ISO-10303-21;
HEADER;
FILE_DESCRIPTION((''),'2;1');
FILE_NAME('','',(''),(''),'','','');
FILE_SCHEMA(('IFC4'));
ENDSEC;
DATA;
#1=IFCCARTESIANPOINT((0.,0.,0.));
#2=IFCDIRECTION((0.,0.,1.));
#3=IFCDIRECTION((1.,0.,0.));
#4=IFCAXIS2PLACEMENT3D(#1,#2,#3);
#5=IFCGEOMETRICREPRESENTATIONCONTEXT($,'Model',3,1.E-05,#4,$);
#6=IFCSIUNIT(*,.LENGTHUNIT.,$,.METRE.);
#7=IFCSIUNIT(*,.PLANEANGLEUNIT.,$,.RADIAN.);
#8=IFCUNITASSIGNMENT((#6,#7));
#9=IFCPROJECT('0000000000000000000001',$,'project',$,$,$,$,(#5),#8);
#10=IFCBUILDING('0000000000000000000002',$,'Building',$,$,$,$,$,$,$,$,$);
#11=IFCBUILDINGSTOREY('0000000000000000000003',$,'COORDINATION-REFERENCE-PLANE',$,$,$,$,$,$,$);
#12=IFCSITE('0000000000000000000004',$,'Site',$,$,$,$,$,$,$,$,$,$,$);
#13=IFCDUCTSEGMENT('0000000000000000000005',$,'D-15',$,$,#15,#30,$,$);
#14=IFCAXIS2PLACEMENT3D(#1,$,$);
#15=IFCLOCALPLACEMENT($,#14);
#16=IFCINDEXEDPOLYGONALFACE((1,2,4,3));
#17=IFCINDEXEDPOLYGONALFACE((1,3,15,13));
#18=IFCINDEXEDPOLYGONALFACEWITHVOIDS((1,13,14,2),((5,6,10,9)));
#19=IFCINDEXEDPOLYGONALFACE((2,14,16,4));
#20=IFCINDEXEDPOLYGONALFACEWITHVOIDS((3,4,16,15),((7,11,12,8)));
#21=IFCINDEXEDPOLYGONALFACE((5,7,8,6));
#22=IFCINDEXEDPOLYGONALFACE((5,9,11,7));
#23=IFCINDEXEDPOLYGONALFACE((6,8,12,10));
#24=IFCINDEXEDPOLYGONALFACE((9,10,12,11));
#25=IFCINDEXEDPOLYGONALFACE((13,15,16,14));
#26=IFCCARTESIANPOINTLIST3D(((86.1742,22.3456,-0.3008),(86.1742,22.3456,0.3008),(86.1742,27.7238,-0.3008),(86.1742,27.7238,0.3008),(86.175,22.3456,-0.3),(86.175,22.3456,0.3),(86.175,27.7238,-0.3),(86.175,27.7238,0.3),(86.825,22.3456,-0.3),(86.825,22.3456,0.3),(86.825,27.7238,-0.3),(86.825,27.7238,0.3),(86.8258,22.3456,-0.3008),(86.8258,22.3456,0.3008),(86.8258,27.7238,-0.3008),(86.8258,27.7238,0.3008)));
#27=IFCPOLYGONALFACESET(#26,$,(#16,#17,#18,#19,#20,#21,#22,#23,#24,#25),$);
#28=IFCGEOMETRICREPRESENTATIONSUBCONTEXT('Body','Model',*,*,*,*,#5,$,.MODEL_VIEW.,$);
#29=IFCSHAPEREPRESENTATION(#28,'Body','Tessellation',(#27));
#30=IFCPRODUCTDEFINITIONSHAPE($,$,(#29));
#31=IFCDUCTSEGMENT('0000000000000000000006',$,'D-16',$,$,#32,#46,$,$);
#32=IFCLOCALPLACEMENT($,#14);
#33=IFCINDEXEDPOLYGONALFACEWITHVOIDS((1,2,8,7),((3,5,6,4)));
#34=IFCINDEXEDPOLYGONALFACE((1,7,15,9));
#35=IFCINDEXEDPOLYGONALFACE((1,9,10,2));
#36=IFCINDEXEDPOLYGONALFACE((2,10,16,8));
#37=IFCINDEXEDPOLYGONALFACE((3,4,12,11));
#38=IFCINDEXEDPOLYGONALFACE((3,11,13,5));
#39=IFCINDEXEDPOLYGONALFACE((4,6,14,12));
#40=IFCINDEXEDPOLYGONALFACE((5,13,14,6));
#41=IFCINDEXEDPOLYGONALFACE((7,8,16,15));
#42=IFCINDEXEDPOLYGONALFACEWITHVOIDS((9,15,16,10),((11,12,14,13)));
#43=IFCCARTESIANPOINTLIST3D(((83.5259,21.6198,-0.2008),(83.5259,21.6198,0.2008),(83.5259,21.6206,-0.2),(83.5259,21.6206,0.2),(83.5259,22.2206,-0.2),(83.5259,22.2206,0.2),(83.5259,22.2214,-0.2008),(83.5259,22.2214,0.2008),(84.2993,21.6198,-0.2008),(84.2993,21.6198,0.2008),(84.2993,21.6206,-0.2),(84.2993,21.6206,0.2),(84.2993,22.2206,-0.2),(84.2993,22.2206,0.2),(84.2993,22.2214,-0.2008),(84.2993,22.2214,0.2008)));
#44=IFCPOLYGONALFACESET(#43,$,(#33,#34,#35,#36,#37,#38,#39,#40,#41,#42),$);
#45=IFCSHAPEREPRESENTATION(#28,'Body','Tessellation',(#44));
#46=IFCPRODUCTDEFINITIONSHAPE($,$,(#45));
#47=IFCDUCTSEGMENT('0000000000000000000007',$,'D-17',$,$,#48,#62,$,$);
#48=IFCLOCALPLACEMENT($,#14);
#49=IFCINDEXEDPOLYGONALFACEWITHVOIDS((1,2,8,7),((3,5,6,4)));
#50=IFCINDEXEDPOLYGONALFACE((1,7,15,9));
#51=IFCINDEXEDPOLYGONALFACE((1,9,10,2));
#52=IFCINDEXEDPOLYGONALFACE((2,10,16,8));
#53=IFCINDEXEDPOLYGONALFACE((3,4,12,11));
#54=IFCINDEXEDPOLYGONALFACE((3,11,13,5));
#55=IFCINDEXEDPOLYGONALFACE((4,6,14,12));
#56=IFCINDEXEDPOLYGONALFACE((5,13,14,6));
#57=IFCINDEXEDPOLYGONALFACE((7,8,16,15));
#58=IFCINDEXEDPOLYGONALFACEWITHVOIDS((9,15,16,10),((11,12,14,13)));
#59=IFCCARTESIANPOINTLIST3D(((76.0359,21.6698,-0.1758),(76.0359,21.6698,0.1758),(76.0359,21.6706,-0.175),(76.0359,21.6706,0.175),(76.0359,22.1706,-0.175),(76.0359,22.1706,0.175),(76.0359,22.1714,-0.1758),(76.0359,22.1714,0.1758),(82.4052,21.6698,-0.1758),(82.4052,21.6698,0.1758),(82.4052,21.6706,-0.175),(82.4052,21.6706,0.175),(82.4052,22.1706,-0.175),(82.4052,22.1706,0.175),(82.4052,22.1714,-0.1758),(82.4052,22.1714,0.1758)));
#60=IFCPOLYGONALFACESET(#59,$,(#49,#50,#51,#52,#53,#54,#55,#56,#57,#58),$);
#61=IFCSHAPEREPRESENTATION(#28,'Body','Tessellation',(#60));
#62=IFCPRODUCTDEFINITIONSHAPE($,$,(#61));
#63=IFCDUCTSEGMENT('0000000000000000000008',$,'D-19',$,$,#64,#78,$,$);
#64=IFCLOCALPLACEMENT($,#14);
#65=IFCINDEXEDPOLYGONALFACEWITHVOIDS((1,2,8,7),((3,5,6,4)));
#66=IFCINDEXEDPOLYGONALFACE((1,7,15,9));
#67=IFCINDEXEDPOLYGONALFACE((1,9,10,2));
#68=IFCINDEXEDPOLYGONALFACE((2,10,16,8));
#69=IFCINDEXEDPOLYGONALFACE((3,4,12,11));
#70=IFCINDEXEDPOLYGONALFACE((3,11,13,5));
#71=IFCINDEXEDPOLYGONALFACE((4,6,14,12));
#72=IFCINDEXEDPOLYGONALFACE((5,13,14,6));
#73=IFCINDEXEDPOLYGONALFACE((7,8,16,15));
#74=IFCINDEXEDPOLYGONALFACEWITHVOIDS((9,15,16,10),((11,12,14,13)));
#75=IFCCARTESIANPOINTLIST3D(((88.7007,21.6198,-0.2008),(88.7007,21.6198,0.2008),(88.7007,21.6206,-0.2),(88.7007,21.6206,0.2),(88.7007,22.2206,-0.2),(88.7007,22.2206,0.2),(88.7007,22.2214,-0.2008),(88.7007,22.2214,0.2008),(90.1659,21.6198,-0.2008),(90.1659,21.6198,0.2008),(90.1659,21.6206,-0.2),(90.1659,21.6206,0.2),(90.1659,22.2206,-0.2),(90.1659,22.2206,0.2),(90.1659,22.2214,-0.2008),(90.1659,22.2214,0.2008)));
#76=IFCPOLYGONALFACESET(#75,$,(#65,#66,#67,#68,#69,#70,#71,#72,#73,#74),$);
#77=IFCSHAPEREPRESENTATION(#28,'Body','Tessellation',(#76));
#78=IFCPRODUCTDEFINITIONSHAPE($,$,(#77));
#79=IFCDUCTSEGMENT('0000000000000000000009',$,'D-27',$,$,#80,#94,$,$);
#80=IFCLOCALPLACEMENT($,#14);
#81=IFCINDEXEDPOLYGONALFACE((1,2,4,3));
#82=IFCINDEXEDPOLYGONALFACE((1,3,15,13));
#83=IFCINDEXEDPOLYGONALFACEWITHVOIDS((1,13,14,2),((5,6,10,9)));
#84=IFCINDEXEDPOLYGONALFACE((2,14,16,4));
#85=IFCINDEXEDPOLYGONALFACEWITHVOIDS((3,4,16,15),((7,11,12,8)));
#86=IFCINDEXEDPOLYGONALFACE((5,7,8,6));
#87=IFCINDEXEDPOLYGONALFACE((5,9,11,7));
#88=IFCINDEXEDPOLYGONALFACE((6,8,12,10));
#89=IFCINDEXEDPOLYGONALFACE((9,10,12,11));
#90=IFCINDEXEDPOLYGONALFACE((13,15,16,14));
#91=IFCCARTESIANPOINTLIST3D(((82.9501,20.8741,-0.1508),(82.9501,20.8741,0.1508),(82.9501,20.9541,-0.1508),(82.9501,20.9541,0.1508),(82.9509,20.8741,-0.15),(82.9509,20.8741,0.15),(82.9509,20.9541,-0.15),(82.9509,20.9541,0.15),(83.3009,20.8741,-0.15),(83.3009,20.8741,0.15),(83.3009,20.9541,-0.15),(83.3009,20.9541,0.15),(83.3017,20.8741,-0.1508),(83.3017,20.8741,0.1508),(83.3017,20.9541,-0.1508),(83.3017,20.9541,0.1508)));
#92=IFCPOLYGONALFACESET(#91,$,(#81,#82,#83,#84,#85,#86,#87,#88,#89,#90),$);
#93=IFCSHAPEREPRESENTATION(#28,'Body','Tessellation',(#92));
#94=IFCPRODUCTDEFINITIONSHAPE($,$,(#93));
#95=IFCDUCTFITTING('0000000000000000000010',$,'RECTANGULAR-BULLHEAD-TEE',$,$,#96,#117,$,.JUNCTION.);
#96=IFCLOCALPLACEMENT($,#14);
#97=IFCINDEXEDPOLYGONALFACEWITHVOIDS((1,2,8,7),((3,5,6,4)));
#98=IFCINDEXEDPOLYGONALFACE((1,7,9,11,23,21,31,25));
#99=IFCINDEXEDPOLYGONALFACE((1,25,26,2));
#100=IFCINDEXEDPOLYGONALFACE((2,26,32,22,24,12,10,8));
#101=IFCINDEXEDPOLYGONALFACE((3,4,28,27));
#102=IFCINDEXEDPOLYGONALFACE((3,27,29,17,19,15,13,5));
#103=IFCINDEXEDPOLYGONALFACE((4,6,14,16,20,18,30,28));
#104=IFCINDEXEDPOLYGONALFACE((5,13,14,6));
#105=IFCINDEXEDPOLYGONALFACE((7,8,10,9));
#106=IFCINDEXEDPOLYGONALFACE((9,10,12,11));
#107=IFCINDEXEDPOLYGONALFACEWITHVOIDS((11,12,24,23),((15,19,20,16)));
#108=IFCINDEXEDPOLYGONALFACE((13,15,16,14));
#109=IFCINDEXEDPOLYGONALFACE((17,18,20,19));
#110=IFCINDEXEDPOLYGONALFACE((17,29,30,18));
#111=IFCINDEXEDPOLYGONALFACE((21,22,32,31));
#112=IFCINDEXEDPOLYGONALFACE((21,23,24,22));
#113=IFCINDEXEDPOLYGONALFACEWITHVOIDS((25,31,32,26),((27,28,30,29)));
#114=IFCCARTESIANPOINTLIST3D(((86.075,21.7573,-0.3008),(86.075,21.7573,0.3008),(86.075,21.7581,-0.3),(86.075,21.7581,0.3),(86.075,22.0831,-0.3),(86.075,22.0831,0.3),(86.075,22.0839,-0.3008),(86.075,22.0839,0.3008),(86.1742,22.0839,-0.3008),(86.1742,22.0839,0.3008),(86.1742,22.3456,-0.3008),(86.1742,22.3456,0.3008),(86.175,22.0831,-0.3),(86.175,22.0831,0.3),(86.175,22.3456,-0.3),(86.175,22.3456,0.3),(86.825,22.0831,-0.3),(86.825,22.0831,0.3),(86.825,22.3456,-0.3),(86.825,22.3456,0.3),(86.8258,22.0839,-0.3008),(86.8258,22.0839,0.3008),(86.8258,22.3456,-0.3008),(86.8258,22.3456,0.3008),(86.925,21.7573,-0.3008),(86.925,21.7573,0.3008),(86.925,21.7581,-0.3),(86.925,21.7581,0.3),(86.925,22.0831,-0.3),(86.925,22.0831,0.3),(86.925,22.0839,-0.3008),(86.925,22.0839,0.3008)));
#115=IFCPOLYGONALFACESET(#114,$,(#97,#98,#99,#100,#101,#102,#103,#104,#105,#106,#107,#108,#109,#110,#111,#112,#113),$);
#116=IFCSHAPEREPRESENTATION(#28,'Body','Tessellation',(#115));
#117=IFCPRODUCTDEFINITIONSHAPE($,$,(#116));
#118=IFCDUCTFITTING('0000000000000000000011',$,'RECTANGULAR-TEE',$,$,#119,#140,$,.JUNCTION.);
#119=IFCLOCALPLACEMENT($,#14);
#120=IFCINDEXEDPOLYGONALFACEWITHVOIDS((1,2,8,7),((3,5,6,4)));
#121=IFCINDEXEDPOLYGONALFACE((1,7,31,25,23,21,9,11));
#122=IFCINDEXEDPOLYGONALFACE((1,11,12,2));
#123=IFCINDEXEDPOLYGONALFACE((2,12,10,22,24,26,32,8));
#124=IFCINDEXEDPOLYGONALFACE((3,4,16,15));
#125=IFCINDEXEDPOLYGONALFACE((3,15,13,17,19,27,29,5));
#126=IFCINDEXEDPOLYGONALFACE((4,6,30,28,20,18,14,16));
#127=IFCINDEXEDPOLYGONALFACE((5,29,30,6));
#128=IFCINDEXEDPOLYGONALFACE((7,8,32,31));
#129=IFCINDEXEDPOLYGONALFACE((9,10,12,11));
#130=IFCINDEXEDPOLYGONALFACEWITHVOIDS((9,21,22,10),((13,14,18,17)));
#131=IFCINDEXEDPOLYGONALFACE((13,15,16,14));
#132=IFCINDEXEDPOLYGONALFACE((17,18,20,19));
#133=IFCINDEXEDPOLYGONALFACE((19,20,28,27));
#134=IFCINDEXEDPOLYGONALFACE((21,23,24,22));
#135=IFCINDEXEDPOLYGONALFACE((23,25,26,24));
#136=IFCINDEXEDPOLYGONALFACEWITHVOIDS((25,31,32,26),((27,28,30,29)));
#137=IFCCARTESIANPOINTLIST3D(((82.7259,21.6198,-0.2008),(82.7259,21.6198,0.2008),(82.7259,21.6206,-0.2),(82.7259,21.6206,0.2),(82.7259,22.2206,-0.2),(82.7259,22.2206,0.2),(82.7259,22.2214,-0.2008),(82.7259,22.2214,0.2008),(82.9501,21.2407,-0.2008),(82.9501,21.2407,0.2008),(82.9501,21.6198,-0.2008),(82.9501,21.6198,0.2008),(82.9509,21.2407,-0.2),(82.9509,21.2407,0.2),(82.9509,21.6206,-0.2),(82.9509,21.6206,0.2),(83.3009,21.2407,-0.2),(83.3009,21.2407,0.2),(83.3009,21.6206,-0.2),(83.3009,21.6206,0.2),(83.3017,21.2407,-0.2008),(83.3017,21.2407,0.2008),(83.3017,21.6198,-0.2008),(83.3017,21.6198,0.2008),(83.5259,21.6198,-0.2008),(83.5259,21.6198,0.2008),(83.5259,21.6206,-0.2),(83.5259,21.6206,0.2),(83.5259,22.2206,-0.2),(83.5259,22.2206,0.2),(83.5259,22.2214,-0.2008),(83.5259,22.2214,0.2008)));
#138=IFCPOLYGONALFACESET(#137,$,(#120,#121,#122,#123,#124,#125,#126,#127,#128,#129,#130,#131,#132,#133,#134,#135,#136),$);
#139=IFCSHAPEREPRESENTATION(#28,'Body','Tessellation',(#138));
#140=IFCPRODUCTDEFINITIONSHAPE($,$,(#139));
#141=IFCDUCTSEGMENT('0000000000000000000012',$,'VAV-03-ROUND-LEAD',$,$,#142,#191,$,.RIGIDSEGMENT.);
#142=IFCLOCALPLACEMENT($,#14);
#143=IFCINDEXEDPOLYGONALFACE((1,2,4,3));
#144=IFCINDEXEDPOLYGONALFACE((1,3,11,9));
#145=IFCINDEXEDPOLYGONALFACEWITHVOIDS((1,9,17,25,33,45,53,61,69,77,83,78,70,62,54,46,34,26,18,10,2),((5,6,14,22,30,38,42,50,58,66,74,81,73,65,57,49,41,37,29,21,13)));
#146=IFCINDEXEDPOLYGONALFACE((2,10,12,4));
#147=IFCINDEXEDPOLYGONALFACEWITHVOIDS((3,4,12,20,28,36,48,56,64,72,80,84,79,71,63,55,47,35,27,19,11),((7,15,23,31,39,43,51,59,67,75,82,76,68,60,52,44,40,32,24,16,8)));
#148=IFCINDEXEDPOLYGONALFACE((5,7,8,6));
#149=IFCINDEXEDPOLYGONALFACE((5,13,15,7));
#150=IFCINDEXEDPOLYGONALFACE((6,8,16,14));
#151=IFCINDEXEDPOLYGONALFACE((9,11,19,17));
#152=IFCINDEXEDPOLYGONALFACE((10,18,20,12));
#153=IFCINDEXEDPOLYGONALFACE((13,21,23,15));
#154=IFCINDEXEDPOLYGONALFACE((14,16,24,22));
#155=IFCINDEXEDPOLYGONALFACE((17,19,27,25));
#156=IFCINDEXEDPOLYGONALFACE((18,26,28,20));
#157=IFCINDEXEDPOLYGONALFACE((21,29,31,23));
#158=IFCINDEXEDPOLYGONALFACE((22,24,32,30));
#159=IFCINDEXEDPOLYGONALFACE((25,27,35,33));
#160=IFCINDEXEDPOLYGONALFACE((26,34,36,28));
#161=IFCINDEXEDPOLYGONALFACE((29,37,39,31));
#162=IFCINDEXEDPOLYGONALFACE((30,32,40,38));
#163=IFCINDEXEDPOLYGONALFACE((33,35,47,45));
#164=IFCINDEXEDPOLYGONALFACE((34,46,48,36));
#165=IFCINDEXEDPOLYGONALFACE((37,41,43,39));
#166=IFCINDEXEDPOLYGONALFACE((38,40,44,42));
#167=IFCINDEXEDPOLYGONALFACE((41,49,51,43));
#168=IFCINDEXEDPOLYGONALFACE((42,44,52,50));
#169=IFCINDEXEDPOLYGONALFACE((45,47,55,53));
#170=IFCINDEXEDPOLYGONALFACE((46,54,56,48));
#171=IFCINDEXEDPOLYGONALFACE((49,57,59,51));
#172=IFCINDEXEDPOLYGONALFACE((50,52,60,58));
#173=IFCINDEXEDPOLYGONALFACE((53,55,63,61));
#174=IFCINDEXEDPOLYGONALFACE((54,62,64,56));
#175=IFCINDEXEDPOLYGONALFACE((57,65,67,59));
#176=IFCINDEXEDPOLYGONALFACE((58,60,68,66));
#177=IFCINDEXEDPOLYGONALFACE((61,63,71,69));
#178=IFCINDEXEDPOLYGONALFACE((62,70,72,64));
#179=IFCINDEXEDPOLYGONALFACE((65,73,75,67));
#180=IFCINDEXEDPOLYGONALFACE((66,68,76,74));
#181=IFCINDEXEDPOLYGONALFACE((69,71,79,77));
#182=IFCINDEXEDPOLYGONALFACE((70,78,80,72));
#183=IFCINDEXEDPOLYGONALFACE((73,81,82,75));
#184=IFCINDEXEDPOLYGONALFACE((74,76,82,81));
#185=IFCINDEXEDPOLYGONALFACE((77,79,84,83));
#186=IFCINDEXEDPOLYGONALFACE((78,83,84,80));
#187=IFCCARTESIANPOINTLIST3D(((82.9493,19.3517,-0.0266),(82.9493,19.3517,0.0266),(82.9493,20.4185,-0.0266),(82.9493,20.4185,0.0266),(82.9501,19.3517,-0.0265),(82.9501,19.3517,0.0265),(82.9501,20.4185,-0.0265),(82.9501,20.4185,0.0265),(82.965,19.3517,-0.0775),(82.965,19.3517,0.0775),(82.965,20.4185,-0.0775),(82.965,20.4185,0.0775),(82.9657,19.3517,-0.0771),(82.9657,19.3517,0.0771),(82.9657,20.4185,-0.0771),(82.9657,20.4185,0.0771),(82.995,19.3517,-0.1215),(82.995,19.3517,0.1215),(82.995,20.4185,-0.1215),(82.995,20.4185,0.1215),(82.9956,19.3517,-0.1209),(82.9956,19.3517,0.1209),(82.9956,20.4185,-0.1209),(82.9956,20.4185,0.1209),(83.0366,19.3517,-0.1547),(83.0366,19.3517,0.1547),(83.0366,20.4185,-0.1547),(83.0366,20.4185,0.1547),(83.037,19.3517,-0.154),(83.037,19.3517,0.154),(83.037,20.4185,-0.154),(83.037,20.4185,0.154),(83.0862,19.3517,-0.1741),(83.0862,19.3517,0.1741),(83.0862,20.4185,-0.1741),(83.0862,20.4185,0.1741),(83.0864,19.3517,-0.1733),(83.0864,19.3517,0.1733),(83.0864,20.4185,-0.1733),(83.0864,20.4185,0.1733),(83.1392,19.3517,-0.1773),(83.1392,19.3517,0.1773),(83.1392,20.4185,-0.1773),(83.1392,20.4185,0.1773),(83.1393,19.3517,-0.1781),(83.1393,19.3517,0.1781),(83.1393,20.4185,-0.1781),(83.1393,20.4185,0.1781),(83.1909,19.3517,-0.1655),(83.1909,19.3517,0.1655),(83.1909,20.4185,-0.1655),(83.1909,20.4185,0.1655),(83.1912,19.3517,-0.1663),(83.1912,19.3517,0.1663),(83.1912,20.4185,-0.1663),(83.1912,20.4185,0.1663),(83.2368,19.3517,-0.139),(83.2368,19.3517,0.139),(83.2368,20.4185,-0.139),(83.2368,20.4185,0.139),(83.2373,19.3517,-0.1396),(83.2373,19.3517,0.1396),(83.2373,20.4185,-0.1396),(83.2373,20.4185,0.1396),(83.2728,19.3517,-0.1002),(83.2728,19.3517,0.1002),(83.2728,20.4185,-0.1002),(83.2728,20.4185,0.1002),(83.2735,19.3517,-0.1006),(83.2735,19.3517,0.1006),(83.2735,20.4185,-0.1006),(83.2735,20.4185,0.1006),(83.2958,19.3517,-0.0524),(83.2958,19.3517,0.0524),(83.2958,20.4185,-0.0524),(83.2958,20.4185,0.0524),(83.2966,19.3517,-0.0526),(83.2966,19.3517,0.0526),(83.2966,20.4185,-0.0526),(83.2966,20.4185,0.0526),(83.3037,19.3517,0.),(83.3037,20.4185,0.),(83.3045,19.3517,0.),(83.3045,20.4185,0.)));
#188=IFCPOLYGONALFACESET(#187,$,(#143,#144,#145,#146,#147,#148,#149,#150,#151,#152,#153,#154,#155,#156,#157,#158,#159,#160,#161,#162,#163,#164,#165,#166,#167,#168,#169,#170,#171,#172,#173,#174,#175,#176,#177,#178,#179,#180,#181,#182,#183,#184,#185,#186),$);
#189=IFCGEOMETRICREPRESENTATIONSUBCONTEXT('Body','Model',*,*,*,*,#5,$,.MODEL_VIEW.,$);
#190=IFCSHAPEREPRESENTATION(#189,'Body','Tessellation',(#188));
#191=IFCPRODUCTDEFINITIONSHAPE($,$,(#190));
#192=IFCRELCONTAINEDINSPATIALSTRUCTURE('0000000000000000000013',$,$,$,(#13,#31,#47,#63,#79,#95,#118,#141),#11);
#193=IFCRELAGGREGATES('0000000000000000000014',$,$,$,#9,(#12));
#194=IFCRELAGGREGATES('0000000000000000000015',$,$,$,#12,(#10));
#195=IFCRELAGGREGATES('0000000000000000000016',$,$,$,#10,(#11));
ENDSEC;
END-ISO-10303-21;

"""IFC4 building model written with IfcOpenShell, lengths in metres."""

from ifc_helpers import new_model, si_unit, frame, origin, origin_with_axes, place, context, subcontext, project, spatial, rectangle, hollow_rectangle, hollow_circle, extrude, boolean, element, save


model = new_model("IFC4")

# Units and contexts
model_context = context("Model", 3, precision=1e-05, world=origin_with_axes())
body_context_1 = subcontext(model_context, "Body", "Model", "MODEL_VIEW")
body_context_2 = subcontext(model_context, "Body", "Model", "MODEL_VIEW")
ifc_project = project(units=[si_unit("LENGTHUNIT", "METRE"), si_unit("PLANEANGLEUNIT", "RADIAN")], contexts=[model_context])

# Site, building, storey
site = spatial("IfcSite", under=ifc_project, Name="Site")
building = spatial("IfcBuilding", under=site, Name="Building")
storey = spatial("IfcBuildingStorey", under=building, Name="COORDINATION-REFERENCE-PLANE")

# Duct segments
duct_segment_1_placement = place(None, frame((86.5, 22.3456, 0.0), z_axis=(0.0, 1.0, 0.0), x_axis=(1.0, 0.0, 0.0)))
element("IfcDuctSegment", 1, at=duct_segment_1_placement, inside=storey, Name="D-15", context=body_context_1, shape_type="SweptSolid", body=[
    extrude(hollow_rectangle(XDim=0.6516, YDim=0.6016, WallThickness=0.0008), origin(), (0.0, 0.0, 1.0), 5.3782),
])
duct_segment_2_placement = place(None, frame((83.5259, 21.9206, 0.0), z_axis=(1.0, 0.0, 0.0), x_axis=(0.0, 1.0, 0.0)))
element("IfcDuctSegment", 2, at=duct_segment_2_placement, inside=storey, Name="D-16", context=body_context_1, shape_type="SweptSolid", body=[
    extrude(hollow_rectangle(XDim=0.6016, YDim=0.4016, WallThickness=0.0008), origin(), (0.0, 0.0, 1.0), 0.7733),
])
duct_segment_3_placement = place(None, frame((76.0359, 21.9206, 0.0), z_axis=(1.0, 0.0, 0.0), x_axis=(0.0, 1.0, 0.0)))
element("IfcDuctSegment", 3, at=duct_segment_3_placement, inside=storey, Name="D-17", context=body_context_1, shape_type="SweptSolid", body=[
    extrude(hollow_rectangle(XDim=0.5016, YDim=0.3516, WallThickness=0.0008), origin(), (0.0, 0.0, 1.0), 6.3693),
])
duct_segment_4_placement = place(None, frame((88.7007, 21.9206, 0.0), z_axis=(1.0, 0.0, 0.0), x_axis=(0.0, 1.0, 0.0)))
element("IfcDuctSegment", 4, at=duct_segment_4_placement, inside=storey, Name="D-19", context=body_context_1, shape_type="SweptSolid", body=[
    extrude(hollow_rectangle(XDim=0.6016, YDim=0.4016, WallThickness=0.0008), origin(), (0.0, 0.0, 1.0), 1.4652),
])
duct_segment_5_placement = place(None, frame((83.1259, 20.8741, 0.0), z_axis=(0.0, 1.0, 0.0), x_axis=(1.0, 0.0, 0.0)))
element("IfcDuctSegment", 5, at=duct_segment_5_placement, inside=storey, Name="D-27", context=body_context_1, shape_type="SweptSolid", body=[
    extrude(hollow_rectangle(XDim=0.3516, YDim=0.3016, WallThickness=0.0008), origin(), (0.0, 0.0, 1.0), 0.08),
])

# Duct fittings
duct_fitting_1_placement = place(None, frame((86.5, 21.9206, 0.0), z_axis=(1.0, 0.0, 0.0), x_axis=(0.0, 1.0, 0.0)))
solid_1 = boolean("UNION", extrude(rectangle(XDim=0.325, YDim=0.6), frame((0.0, 0.0, -0.425), z_axis=(0.0, 0.0, 1.0), x_axis=(1.0, 0.0, 0.0)), (0.0, 0.0, 1.0), 0.85), extrude(rectangle(XDim=0.65, YDim=0.6), frame((0.0, 0.0, 0.0), z_axis=(1.0, 0.0, 0.0), x_axis=(0.0, 0.0, -1.0)), (0.0, 0.0, 1.0), 0.425))
element("IfcDuctFitting", 6, at=duct_fitting_1_placement, inside=storey, Name="RECTANGULAR-BULLHEAD-TEE", PredefinedType="JUNCTION", context=body_context_1, shape_type="CSG", body=[
    boolean("DIFFERENCE", boolean("UNION", extrude(rectangle(XDim=0.3266, YDim=0.6016), frame((0.0, 0.0, -0.425), z_axis=(0.0, 0.0, 1.0), x_axis=(1.0, 0.0, 0.0)), (0.0, 0.0, 1.0), 0.85), extrude(rectangle(XDim=0.6516, YDim=0.6016), frame((0.0, 0.0, 0.0), z_axis=(1.0, 0.0, 0.0), x_axis=(0.0, 0.0, -1.0)), (0.0, 0.0, 1.0), 0.425)), solid_1),
])
duct_fitting_2_placement = place(None, frame((83.1259, 21.9206, 0.0), z_axis=(-1.0, 0.0, 0.0), x_axis=(0.0, -1.0, 0.0)))
solid_2 = boolean("UNION", extrude(rectangle(XDim=0.6, YDim=0.4), frame((0.0, 0.0, -0.4), z_axis=(0.0, 0.0, 1.0), x_axis=(1.0, 0.0, 0.0)), (0.0, 0.0, 1.0), 0.8), extrude(rectangle(XDim=0.35, YDim=0.4), frame((0.0, 0.0, 0.0), z_axis=(1.0, 0.0, 0.0), x_axis=(0.0, 0.0, -1.0)), (0.0, 0.0, 1.0), 0.6799))
element("IfcDuctFitting", 7, at=duct_fitting_2_placement, inside=storey, Name="RECTANGULAR-TEE", PredefinedType="JUNCTION", context=body_context_1, shape_type="CSG", body=[
    boolean("DIFFERENCE", boolean("UNION", extrude(rectangle(XDim=0.6016, YDim=0.4016), frame((0.0, 0.0, -0.4), z_axis=(0.0, 0.0, 1.0), x_axis=(1.0, 0.0, 0.0)), (0.0, 0.0, 1.0), 0.8), extrude(rectangle(XDim=0.3516, YDim=0.4016), frame((0.0, 0.0, 0.0), z_axis=(1.0, 0.0, 0.0), x_axis=(0.0, 0.0, -1.0)), (0.0, 0.0, 1.0), 0.6799)), solid_2),
])

# Duct segment
duct_segment_6_placement = place(None, frame((83.1259, 20.4185, 0.0), z_axis=(0.0, -1.0, 0.0), x_axis=(1.0, 0.0, 0.0)))
element("IfcDuctSegment", 8, at=duct_segment_6_placement, inside=storey, Name="VAV-03-ROUND-LEAD", PredefinedType="RIGIDSEGMENT", context=body_context_2, shape_type="SweptSolid", body=[
    extrude(hollow_circle(Radius=0.1786, WallThickness=0.0008), origin(), (0.0, 0.0, 1.0), 1.0668),
])

save(model, "model.ifc")
